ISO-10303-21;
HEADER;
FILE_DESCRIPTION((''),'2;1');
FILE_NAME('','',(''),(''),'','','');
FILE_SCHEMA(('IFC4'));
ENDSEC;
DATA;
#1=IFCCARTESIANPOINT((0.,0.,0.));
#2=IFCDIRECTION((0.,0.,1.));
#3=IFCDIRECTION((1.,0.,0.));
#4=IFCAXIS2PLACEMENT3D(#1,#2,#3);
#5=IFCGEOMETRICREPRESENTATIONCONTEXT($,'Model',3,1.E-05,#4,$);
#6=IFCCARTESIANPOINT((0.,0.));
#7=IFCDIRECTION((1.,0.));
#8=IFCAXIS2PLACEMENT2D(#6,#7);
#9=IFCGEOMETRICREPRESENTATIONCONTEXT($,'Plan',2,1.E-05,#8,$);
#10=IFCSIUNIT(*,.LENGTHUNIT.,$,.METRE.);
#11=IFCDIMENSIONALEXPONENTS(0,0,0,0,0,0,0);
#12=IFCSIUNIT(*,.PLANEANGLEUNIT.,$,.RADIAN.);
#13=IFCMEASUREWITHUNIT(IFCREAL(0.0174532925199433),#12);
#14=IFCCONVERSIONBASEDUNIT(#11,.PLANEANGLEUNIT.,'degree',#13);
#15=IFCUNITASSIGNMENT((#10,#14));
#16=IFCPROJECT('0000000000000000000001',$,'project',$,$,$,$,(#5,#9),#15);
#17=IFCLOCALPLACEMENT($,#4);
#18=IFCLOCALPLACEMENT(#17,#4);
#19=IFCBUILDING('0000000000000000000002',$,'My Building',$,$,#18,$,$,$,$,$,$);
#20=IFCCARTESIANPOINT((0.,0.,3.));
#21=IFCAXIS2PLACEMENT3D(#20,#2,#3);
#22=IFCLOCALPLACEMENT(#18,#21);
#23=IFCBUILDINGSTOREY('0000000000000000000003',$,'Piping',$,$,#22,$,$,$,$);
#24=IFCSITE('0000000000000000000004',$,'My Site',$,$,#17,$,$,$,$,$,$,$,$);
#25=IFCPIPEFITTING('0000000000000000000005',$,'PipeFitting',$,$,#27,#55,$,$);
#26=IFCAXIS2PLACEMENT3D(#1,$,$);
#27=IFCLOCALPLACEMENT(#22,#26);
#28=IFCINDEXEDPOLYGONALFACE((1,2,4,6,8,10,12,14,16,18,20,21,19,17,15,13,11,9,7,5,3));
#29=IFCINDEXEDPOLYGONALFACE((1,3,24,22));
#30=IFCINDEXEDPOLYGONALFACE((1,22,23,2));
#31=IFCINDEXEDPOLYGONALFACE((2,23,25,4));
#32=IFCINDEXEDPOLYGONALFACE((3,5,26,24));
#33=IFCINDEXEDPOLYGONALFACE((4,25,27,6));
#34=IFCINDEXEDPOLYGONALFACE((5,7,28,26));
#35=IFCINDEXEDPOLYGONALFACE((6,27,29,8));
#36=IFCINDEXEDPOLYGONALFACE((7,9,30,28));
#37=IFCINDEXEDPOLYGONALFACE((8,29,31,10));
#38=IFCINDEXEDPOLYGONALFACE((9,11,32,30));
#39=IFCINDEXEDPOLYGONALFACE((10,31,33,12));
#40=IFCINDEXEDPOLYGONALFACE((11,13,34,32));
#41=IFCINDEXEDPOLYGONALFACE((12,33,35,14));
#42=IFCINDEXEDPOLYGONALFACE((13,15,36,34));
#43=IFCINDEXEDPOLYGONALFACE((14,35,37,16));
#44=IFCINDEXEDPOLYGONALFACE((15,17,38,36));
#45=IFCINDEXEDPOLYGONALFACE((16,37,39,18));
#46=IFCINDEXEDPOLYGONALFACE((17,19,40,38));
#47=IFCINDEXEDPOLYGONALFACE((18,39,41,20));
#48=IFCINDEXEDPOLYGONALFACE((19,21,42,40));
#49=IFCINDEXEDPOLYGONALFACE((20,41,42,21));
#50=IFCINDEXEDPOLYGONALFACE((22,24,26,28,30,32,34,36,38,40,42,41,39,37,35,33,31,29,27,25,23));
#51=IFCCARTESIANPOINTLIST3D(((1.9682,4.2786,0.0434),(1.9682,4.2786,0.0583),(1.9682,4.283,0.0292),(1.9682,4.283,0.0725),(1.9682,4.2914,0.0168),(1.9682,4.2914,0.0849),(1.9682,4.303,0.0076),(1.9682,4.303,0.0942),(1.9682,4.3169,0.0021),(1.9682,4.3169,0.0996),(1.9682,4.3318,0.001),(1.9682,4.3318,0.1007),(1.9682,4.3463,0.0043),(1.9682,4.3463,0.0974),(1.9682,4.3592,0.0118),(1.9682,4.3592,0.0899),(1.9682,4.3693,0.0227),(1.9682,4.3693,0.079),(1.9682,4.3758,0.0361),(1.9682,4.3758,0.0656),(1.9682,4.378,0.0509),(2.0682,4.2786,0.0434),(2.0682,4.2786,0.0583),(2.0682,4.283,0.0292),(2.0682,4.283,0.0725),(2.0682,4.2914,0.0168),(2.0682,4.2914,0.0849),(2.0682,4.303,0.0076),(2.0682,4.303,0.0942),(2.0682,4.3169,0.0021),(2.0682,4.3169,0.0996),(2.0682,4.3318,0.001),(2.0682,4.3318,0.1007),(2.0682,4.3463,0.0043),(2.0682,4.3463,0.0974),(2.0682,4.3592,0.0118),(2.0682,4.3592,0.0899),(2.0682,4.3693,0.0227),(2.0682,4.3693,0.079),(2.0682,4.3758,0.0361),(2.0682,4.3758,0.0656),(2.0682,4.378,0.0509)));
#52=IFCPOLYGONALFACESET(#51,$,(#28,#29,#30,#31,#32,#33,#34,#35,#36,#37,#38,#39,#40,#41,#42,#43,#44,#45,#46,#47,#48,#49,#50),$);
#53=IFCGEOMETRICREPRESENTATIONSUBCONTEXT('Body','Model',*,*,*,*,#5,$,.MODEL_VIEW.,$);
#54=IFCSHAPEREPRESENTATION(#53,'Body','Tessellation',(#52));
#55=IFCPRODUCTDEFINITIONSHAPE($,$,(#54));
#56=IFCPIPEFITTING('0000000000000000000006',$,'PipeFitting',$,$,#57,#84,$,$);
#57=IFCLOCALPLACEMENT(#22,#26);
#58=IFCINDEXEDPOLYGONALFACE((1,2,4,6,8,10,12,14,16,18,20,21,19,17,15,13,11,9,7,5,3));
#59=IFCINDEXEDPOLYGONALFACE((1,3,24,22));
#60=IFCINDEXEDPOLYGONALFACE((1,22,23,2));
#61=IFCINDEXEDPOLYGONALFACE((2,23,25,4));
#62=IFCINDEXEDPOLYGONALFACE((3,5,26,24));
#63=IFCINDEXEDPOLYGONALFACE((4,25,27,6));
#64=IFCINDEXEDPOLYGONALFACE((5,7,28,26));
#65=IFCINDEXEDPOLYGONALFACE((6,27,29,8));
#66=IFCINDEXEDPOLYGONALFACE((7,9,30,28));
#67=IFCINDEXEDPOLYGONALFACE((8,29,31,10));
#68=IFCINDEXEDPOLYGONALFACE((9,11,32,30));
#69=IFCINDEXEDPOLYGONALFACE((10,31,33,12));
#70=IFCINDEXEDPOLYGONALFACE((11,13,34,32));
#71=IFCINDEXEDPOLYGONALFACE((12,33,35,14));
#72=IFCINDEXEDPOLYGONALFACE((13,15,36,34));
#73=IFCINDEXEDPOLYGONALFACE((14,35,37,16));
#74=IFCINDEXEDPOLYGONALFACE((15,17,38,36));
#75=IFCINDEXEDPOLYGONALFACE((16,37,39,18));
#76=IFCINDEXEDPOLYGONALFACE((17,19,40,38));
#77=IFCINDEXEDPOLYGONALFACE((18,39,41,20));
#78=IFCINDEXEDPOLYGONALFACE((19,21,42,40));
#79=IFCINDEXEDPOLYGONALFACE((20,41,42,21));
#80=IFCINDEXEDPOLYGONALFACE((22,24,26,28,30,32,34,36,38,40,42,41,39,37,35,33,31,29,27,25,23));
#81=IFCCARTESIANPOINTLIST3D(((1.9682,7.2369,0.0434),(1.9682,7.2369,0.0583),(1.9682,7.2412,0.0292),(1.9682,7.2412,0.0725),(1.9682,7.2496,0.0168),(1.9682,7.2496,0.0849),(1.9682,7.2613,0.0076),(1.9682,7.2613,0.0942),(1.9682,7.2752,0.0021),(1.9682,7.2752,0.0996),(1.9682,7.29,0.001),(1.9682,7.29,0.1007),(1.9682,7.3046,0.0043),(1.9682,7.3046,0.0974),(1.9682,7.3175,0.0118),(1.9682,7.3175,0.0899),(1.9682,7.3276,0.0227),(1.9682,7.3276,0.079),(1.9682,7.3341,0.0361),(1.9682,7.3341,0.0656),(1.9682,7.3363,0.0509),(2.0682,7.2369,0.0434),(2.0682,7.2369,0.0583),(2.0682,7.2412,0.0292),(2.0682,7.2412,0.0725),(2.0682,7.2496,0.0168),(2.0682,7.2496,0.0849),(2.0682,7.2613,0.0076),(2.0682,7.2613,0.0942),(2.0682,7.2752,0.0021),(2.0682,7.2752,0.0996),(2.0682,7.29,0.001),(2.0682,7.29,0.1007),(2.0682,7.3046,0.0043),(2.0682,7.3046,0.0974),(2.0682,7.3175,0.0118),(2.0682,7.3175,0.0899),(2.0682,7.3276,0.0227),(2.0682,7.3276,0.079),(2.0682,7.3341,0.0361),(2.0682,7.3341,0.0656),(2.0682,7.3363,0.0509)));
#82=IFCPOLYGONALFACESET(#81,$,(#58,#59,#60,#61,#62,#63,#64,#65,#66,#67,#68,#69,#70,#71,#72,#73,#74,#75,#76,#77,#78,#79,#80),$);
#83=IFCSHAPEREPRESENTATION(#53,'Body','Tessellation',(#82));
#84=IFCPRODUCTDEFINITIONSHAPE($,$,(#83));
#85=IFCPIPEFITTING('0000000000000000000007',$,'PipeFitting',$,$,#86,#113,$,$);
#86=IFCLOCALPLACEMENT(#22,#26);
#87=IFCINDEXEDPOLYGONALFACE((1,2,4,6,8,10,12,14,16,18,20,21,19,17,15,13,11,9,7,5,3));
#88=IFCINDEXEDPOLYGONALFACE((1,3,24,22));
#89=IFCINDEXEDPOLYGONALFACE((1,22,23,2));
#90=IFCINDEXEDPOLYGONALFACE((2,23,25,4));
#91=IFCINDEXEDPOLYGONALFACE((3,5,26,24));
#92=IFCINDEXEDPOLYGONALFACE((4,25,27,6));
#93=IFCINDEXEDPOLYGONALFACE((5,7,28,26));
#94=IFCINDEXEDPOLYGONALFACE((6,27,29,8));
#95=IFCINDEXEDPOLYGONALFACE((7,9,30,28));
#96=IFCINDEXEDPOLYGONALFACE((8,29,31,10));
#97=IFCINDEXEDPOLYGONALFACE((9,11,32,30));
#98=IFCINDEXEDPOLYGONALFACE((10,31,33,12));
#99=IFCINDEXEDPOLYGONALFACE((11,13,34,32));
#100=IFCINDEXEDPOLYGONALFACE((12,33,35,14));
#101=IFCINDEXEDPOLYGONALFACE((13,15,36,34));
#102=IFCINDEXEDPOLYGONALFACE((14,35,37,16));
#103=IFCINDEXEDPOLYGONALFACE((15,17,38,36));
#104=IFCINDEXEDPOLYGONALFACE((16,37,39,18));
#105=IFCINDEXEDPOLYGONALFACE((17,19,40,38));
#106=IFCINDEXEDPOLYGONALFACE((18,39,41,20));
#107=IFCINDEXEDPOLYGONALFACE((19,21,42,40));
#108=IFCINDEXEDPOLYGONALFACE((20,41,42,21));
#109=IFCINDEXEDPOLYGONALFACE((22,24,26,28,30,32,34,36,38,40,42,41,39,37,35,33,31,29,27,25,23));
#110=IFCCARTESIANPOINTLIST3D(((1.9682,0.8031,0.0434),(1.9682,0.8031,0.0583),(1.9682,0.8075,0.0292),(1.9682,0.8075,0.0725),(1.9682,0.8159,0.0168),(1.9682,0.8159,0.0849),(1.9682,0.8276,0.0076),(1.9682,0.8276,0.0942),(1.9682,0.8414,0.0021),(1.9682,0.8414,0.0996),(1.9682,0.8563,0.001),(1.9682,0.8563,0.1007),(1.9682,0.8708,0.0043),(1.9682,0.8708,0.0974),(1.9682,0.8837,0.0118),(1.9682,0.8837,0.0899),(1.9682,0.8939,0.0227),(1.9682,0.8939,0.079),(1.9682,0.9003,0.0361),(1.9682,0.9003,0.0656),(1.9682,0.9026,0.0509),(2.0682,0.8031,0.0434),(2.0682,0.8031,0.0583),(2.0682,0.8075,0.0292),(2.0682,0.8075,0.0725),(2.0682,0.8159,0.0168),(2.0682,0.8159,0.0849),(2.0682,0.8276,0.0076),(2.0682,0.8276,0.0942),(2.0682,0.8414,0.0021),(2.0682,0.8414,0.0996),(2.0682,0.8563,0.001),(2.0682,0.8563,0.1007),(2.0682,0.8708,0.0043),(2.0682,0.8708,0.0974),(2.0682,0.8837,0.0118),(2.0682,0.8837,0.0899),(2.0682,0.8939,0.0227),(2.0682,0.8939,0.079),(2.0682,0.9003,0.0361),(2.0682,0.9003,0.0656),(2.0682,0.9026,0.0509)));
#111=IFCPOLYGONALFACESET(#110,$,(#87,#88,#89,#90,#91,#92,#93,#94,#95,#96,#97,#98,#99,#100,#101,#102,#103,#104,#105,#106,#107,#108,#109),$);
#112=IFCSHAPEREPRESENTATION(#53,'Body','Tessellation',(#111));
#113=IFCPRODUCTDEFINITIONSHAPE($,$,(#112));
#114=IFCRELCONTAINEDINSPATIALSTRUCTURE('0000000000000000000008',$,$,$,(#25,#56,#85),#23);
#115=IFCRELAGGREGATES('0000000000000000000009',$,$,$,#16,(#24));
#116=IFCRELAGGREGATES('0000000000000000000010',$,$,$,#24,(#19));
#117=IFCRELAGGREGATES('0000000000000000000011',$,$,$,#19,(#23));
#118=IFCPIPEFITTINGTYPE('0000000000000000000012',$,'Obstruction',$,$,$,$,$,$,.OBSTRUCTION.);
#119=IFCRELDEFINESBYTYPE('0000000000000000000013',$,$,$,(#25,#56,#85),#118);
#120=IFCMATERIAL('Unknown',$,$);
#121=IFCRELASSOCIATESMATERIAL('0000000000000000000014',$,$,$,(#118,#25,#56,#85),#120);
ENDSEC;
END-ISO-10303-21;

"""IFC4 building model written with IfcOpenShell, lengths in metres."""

from ifc_helpers import new_model, entity, si_unit, converted_unit, frame, origin_with_axes, origin_2d_with_axis, place, context, subcontext, project, spatial, circle, extrude, material, material_profile, profile_set, profile_usage, type_object, element, save


model = new_model("IFC4")

# Units and contexts
model_context = context("Model", 3, precision=1e-05, world=origin_with_axes())
plan_context = context("Plan", 2, precision=1e-05, world=origin_2d_with_axis())
body_context = subcontext(model_context, "Body", "Model", "MODEL_VIEW")
ifc_project = project(units=[si_unit("LENGTHUNIT", "METRE"), converted_unit("PLANEANGLEUNIT", "degree", entity("IfcReal", 0.0174532925199433), si_unit("PLANEANGLEUNIT", "RADIAN"), dimensions=[0, 0, 0, 0, 0, 0, 0])], contexts=[model_context, plan_context])

# Site, building, storey
site_placement = place(None, origin_with_axes())
site = spatial("IfcSite", under=ifc_project, at=site_placement, Name="My Site")
building_placement = place(site_placement, origin_with_axes())
building = spatial("IfcBuilding", under=site, at=building_placement, Name="My Building")
storey_placement = place(building_placement, frame((0.0, 0.0, 3.0), z_axis=(0.0, 0.0, 1.0), x_axis=(1.0, 0.0, 0.0)))
storey = spatial("IfcBuildingStorey", under=building, at=storey_placement, Name="Piping")

# Shared definitions
ifc_material = material(Name="Unknown")

# Pipe fittings
ifc_material_profile_1 = material_profile(ifc_material, circle(Radius=0.05))
ifc_profile_set_1 = profile_set([ifc_material_profile_1])
pipe_fitting_type = type_object("IfcPipeFittingType", Name="Obstruction", PredefinedType="OBSTRUCTION", material=ifc_profile_set_1)
ifc_profile_usage_1 = profile_usage(ifc_profile_set_1, cardinal=5)
pipe_fitting_1_placement = place(storey_placement, frame((1.9682, 4.328, 0.0509), z_axis=(1.0, 0.0, 0.0), x_axis=(0.0, 1.0, 0.0)))
element("IfcPipeFitting", 1, at=pipe_fitting_1_placement, inside=storey, type_object=pipe_fitting_type, material=ifc_profile_usage_1, Name="PipeFitting", context=body_context, shape_type="SweptSolid", body=[
    extrude(circle(Radius=0.05), origin_with_axes(), (0.0, 0.0, 1.0), 0.1),
])
ifc_profile_usage_2 = profile_usage(ifc_profile_set_1, cardinal=5)
pipe_fitting_2_placement = place(storey_placement, frame((1.9682, 7.2863, 0.0509), z_axis=(1.0, 0.0, 0.0), x_axis=(0.0, 1.0, 0.0)))
element("IfcPipeFitting", 2, at=pipe_fitting_2_placement, inside=storey, type_object=pipe_fitting_type, material=ifc_profile_usage_2, Name="PipeFitting", context=body_context, shape_type="SweptSolid", body=[
    extrude(circle(Radius=0.05), origin_with_axes(), (0.0, 0.0, 1.0), 0.1),
])
ifc_profile_usage_3 = profile_usage(ifc_profile_set_1, cardinal=5)
pipe_fitting_3_placement = place(storey_placement, frame((1.9682, 0.8526, 0.0509), z_axis=(1.0, 0.0, 0.0), x_axis=(0.0, 1.0, 0.0)))
element("IfcPipeFitting", 3, at=pipe_fitting_3_placement, inside=storey, type_object=pipe_fitting_type, material=ifc_profile_usage_3, Name="PipeFitting", context=body_context, shape_type="SweptSolid", body=[
    extrude(circle(Radius=0.05), origin_with_axes(), (0.0, 0.0, 1.0), 0.1),
])

save(model, "model.ifc")
